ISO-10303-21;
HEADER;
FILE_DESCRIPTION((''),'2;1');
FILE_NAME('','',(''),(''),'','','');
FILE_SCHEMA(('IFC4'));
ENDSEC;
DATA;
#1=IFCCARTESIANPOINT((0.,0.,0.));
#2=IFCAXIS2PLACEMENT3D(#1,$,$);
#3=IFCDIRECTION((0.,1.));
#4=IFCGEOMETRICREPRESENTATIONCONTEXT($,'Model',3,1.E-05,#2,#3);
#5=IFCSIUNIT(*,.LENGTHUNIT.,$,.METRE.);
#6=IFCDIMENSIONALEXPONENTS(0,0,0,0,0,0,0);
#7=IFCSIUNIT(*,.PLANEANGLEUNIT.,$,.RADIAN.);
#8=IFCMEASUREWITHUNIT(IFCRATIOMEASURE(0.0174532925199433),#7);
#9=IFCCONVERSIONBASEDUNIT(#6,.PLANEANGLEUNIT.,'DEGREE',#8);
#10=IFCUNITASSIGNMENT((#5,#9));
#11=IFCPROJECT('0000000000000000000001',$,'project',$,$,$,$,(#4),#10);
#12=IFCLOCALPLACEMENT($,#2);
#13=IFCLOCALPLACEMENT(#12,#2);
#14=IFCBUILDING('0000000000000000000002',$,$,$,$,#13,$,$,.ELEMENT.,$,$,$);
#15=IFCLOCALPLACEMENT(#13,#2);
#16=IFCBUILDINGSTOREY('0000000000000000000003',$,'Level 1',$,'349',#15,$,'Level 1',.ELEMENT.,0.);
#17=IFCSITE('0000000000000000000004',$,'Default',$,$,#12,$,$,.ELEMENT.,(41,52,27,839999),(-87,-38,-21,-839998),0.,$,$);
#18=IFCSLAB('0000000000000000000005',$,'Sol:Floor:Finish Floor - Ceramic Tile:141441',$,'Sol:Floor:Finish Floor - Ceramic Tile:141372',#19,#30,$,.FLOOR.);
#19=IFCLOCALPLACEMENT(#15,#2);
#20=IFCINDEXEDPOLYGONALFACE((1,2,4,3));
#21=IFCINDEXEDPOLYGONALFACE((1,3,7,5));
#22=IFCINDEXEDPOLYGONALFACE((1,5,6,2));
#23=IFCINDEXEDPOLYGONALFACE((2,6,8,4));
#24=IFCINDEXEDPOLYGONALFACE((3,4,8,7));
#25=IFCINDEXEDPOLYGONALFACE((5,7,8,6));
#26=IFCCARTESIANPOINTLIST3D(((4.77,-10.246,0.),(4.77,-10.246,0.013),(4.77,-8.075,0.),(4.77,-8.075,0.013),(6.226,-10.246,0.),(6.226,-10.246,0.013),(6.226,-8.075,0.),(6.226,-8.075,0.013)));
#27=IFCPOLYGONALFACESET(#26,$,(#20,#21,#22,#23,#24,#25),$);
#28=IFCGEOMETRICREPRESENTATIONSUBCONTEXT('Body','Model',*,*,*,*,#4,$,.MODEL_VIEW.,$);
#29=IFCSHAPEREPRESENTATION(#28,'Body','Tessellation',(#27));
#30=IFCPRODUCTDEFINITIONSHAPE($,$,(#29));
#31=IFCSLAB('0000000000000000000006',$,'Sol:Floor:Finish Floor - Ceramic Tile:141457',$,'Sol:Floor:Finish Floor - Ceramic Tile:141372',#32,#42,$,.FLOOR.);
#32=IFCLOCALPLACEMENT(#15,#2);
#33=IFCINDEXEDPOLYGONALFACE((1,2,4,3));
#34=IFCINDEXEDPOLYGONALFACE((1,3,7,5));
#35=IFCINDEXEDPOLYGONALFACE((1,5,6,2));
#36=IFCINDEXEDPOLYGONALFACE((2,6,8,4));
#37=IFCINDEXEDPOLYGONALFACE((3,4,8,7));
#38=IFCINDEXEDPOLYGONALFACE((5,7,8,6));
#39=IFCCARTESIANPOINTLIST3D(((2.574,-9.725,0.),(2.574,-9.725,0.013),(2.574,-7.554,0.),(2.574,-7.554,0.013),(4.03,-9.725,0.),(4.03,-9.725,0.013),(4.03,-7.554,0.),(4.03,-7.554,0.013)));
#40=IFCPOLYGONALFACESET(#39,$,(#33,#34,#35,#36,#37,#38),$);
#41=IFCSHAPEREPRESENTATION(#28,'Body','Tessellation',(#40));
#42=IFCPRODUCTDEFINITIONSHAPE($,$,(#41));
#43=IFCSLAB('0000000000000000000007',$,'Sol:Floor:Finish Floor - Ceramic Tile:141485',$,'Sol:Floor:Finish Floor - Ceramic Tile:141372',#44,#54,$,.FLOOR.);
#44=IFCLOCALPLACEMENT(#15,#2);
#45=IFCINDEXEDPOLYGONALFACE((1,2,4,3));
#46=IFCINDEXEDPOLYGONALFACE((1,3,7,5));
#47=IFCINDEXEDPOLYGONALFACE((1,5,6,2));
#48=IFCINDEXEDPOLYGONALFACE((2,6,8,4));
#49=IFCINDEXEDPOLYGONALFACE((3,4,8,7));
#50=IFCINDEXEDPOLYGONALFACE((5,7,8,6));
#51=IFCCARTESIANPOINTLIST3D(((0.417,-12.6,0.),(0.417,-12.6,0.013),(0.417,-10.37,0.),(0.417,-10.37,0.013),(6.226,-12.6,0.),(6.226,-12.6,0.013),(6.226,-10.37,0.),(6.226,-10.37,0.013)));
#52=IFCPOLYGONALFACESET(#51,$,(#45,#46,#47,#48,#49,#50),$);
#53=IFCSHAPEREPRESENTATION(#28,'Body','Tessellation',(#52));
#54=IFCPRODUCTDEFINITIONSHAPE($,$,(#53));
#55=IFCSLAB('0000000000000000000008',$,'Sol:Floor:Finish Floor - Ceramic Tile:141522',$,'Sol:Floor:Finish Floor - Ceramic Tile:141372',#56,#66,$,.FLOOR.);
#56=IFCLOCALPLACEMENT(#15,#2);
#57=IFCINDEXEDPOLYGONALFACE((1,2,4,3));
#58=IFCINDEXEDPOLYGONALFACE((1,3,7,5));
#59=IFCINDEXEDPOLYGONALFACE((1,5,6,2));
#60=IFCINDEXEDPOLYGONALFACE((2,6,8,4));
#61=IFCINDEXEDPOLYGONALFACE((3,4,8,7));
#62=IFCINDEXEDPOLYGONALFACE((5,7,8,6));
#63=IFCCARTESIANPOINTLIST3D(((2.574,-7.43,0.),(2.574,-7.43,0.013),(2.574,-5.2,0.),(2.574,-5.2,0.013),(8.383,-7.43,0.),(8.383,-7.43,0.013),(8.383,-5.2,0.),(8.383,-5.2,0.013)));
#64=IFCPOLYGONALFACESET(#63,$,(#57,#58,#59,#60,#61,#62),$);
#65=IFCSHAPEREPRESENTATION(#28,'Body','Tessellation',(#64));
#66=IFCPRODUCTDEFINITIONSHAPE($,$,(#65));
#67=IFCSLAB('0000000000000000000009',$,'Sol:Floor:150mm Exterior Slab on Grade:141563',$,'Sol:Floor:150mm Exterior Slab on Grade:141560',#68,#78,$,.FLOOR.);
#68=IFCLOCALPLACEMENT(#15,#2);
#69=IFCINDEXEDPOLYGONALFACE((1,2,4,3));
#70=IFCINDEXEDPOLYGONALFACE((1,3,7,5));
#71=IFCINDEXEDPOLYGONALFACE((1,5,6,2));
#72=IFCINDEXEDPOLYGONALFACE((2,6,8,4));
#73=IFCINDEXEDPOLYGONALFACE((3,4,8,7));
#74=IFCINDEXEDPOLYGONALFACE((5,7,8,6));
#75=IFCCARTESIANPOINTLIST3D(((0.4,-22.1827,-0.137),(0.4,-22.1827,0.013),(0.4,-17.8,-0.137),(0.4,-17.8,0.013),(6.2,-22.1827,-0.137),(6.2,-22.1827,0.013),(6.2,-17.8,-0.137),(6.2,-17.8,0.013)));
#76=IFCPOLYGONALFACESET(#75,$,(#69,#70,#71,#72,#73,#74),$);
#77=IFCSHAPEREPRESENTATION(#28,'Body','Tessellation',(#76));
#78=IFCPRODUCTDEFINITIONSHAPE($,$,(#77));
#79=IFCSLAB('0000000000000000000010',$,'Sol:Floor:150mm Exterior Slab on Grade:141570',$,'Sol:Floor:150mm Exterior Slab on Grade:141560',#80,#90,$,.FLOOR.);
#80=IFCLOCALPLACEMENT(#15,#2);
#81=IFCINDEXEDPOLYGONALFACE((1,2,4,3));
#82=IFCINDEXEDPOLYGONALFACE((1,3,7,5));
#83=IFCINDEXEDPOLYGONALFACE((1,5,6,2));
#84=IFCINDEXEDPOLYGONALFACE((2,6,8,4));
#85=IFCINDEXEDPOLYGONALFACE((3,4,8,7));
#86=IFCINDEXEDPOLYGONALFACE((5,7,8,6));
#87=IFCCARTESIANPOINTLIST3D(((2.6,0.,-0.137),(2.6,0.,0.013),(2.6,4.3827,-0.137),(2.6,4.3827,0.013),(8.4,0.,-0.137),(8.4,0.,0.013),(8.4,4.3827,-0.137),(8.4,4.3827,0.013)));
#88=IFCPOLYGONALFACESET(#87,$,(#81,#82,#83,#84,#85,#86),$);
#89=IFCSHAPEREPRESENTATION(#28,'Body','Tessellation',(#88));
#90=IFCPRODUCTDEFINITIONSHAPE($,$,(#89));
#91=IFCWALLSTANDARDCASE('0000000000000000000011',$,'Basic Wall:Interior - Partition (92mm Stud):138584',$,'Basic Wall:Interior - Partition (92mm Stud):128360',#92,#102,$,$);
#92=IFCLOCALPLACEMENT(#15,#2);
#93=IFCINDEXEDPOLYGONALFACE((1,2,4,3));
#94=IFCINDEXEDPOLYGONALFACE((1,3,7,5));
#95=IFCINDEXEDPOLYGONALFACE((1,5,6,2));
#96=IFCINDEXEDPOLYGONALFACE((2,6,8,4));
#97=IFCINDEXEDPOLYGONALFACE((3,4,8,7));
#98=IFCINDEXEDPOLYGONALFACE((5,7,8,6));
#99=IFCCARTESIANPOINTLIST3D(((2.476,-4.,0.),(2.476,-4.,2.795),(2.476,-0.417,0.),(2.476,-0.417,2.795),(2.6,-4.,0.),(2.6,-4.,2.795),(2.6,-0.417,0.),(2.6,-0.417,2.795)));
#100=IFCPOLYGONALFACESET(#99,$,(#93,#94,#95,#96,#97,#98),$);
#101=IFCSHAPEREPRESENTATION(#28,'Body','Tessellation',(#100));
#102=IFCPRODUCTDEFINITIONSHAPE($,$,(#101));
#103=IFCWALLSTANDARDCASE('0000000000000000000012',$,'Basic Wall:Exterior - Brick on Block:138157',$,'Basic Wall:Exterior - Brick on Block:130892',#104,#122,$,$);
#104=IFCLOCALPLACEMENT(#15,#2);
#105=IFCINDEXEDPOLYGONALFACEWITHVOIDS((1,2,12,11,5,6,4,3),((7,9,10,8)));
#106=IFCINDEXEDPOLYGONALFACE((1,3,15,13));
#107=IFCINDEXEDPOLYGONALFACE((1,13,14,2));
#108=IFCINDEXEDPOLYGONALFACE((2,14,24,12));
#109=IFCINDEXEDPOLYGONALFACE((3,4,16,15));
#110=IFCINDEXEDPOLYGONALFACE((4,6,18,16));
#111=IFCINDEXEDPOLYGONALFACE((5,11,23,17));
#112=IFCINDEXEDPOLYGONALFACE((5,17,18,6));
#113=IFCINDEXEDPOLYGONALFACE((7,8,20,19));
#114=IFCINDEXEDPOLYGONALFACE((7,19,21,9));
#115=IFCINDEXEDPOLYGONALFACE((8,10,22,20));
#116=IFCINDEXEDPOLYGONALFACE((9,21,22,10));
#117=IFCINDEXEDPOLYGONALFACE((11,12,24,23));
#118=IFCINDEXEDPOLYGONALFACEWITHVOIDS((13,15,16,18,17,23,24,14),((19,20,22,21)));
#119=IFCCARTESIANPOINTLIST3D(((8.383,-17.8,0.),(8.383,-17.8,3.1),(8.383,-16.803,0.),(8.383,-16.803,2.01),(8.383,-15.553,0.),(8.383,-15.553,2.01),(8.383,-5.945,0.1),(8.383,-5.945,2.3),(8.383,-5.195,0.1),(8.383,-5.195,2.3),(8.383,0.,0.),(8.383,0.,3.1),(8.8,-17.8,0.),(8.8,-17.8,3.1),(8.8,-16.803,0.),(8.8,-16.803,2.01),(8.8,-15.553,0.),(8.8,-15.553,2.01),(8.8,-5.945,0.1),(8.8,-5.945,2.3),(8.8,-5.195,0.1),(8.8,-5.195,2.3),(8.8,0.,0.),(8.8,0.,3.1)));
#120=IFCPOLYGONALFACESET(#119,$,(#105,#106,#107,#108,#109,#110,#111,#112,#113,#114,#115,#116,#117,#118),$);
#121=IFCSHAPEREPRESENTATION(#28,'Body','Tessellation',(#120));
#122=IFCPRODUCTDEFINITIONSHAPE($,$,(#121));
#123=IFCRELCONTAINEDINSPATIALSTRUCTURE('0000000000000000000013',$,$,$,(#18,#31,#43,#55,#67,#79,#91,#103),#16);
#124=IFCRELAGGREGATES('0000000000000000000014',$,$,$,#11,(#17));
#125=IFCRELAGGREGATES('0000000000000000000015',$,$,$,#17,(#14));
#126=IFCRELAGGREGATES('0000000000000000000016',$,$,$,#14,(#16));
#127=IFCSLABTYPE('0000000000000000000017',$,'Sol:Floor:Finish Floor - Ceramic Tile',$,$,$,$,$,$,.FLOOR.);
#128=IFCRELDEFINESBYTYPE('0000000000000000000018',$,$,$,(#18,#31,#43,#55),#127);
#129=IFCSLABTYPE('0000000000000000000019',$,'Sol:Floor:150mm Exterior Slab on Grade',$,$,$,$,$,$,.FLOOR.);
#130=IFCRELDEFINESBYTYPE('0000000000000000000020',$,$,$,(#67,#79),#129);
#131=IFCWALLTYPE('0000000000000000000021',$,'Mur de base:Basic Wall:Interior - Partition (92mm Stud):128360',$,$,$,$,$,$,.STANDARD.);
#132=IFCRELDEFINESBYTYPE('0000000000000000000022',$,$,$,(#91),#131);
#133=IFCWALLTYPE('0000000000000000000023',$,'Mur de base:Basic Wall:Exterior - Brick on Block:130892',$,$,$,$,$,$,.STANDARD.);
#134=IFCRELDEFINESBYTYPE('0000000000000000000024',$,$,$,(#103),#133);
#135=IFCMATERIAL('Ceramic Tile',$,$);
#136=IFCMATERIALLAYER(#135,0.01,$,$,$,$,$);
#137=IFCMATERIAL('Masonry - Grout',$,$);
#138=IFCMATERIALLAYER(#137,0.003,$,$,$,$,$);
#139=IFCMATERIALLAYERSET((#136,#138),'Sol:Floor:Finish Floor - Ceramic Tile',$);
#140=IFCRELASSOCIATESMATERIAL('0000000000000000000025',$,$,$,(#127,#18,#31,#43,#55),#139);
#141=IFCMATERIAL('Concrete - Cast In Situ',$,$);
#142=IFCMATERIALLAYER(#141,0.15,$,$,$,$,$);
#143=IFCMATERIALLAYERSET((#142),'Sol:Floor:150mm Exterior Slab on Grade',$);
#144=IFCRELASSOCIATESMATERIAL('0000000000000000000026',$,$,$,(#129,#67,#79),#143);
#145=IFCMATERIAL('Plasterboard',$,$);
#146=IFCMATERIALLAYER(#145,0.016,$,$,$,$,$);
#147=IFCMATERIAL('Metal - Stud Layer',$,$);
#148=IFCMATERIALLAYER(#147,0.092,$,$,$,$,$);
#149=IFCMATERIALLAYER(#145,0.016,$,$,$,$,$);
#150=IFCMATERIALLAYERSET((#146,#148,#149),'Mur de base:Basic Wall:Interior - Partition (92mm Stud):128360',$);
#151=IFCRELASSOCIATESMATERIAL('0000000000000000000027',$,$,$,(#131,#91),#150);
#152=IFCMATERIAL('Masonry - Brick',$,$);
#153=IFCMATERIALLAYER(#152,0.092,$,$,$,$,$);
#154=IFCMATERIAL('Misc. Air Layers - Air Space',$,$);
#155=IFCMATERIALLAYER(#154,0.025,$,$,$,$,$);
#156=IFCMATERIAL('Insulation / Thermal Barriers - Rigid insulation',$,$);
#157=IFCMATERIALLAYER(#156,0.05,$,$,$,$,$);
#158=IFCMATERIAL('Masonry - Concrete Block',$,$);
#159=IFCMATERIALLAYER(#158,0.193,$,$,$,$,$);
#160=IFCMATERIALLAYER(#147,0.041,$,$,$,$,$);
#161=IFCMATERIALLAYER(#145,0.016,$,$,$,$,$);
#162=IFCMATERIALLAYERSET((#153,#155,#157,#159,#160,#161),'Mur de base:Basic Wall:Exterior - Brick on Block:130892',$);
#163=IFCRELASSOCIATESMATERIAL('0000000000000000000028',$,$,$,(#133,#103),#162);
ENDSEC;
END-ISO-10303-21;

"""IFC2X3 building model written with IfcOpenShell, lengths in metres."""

from ifc_helpers import new_model, entity, si_unit, converted_unit, direction, frame, frame_2d, origin, origin_2d_with_axis, place, context, subcontext, project, spatial, rectangle, extrude, material, layer, layer_set, layer_usage, type_object, element, save


model = new_model("IFC2X3")

# Units and contexts
model_context = context("Model", 3, precision=1e-05, world=origin(), true_north=direction((0.0, 1.0)))
body_context = subcontext(model_context, "Body", "Model", "MODEL_VIEW")
ifc_project = project(units=[si_unit("LENGTHUNIT", "METRE"), converted_unit("PLANEANGLEUNIT", "DEGREE", entity("IfcRatioMeasure", 0.0174532925199433), si_unit("PLANEANGLEUNIT", "RADIAN"), dimensions=[0, 0, 0, 0, 0, 0, 0])], contexts=[model_context])

# Site, building, storey
site_placement = place(None, origin())
site = spatial("IfcSite", under=ifc_project, at=site_placement, Name="Default", CompositionType="ELEMENT", RefLatitude=(41, 52, 27, 839999), RefLongitude=(-87, -38, -21, -839998), RefElevation=0.0)
building_placement = place(site_placement, origin())
building = spatial("IfcBuilding", under=site, at=building_placement, CompositionType="ELEMENT")
storey_placement = place(building_placement, origin())
storey = spatial("IfcBuildingStorey", under=building, at=storey_placement, Name="Level 1", ObjectType="349", LongName="Level 1", CompositionType="ELEMENT", Elevation=0.0)

# Slabs
ifc_material_1 = material(Name="Ceramic Tile")
ifc_layer_1 = layer(ifc_material_1, 0.01)
ifc_material_2 = material(Name="Masonry - Grout")
ifc_layer_2 = layer(ifc_material_2, 0.003)
ifc_layer_set_1 = layer_set([ifc_layer_1, ifc_layer_2], Name="Sol:Floor:Finish Floor - Ceramic Tile")
ifc_layer_usage_1 = layer_usage(ifc_layer_set_1, "AXIS3", "POSITIVE", 0.0)
slab_type_1 = type_object("IfcSlabType", Name="Sol:Floor:Finish Floor - Ceramic Tile", PredefinedType="FLOOR", material=ifc_layer_set_1)
slab_1_placement = place(storey_placement, origin())
element("IfcSlab", 1, at=slab_1_placement, inside=storey, type_object=slab_type_1, material=ifc_layer_usage_1, Name="Sol:Floor:Finish Floor - Ceramic Tile:141441", ObjectType="Sol:Floor:Finish Floor - Ceramic Tile:141372", PredefinedType="FLOOR", context=body_context, shape_type="SweptSolid", body=[
    extrude(rectangle(XDim=2.171, YDim=1.456, at=frame_2d((0.0, 0.0), x_axis=(1.0, 0.0))), frame((5.498, -9.1605, 0.013), z_axis=(0.0, 0.0, -1.0), x_axis=(0.0, 1.0, 0.0)), (0.0, 0.0, 1.0), 0.013),
])
ifc_layer_usage_2 = layer_usage(ifc_layer_set_1, "AXIS3", "POSITIVE", 0.0)
slab_2_placement = place(storey_placement, origin())
element("IfcSlab", 2, at=slab_2_placement, inside=storey, type_object=slab_type_1, material=ifc_layer_usage_2, Name="Sol:Floor:Finish Floor - Ceramic Tile:141457", ObjectType="Sol:Floor:Finish Floor - Ceramic Tile:141372", PredefinedType="FLOOR", context=body_context, shape_type="SweptSolid", body=[
    extrude(rectangle(XDim=2.171, YDim=1.456, at=frame_2d((0.0, 0.0), x_axis=(1.0, 0.0))), frame((3.302, -8.6395, 0.013), z_axis=(0.0, 0.0, -1.0), x_axis=(0.0, 1.0, 0.0)), (0.0, 0.0, 1.0), 0.013),
])
ifc_layer_usage_3 = layer_usage(ifc_layer_set_1, "AXIS3", "POSITIVE", 0.0)
slab_3_placement = place(storey_placement, origin())
element("IfcSlab", 3, at=slab_3_placement, inside=storey, type_object=slab_type_1, material=ifc_layer_usage_3, Name="Sol:Floor:Finish Floor - Ceramic Tile:141485", ObjectType="Sol:Floor:Finish Floor - Ceramic Tile:141372", PredefinedType="FLOOR", context=body_context, shape_type="SweptSolid", body=[
    extrude(rectangle(XDim=2.23, YDim=5.809, at=origin_2d_with_axis()), frame((3.3215, -11.485, 0.013), z_axis=(0.0, 0.0, -1.0), x_axis=(0.0, 1.0, 0.0)), (0.0, 0.0, 1.0), 0.013),
])
ifc_layer_usage_4 = layer_usage(ifc_layer_set_1, "AXIS3", "POSITIVE", 0.0)
slab_4_placement = place(storey_placement, origin())
element("IfcSlab", 4, at=slab_4_placement, inside=storey, type_object=slab_type_1, material=ifc_layer_usage_4, Name="Sol:Floor:Finish Floor - Ceramic Tile:141522", ObjectType="Sol:Floor:Finish Floor - Ceramic Tile:141372", PredefinedType="FLOOR", context=body_context, shape_type="SweptSolid", body=[
    extrude(rectangle(XDim=2.23, YDim=5.809, at=frame_2d((0.0, 0.0), x_axis=(1.0, 0.0))), frame((5.4785, -6.315, 0.013), z_axis=(0.0, 0.0, -1.0), x_axis=(0.0, 1.0, 0.0)), (0.0, 0.0, 1.0), 0.013),
])
ifc_material_3 = material(Name="Concrete - Cast In Situ")
ifc_layer_3 = layer(ifc_material_3, 0.15)
ifc_layer_set_2 = layer_set([ifc_layer_3], Name="Sol:Floor:150mm Exterior Slab on Grade")
ifc_layer_usage_5 = layer_usage(ifc_layer_set_2, "AXIS3", "POSITIVE", 0.0)
slab_type_2 = type_object("IfcSlabType", Name="Sol:Floor:150mm Exterior Slab on Grade", PredefinedType="FLOOR", material=ifc_layer_set_2)
slab_5_placement = place(storey_placement, origin())
element("IfcSlab", 5, at=slab_5_placement, inside=storey, type_object=slab_type_2, material=ifc_layer_usage_5, Name="Sol:Floor:150mm Exterior Slab on Grade:141563", ObjectType="Sol:Floor:150mm Exterior Slab on Grade:141560", PredefinedType="FLOOR", context=body_context, shape_type="SweptSolid", body=[
    extrude(rectangle(XDim=4.3827, YDim=5.8, at=origin_2d_with_axis()), frame((3.3, -19.9914, 0.013), z_axis=(0.0, 0.0, -1.0), x_axis=(0.0, 1.0, 0.0)), (0.0, 0.0, 1.0), 0.15),
])
ifc_layer_usage_6 = layer_usage(ifc_layer_set_2, "AXIS3", "POSITIVE", 0.0)
slab_6_placement = place(storey_placement, origin())
element("IfcSlab", 6, at=slab_6_placement, inside=storey, type_object=slab_type_2, material=ifc_layer_usage_6, Name="Sol:Floor:150mm Exterior Slab on Grade:141570", ObjectType="Sol:Floor:150mm Exterior Slab on Grade:141560", PredefinedType="FLOOR", context=body_context, shape_type="SweptSolid", body=[
    extrude(rectangle(XDim=4.3827, YDim=5.8, at=origin_2d_with_axis()), frame((5.5, 2.1914, 0.013), z_axis=(0.0, 0.0, -1.0), x_axis=(0.0, 1.0, 0.0)), (0.0, 0.0, 1.0), 0.15),
])

# Shared definitions
ifc_material_4 = material(Name="Plasterboard")
ifc_layer_4 = layer(ifc_material_4, 0.016)
ifc_material_5 = material(Name="Metal - Stud Layer")
ifc_layer_5 = layer(ifc_material_5, 0.092)
ifc_layer_6 = layer(ifc_material_4, 0.016)
ifc_layer_set_3 = layer_set([ifc_layer_4, ifc_layer_5, ifc_layer_6], Name="Mur de base:Basic Wall:Interior - Partition (92mm Stud):128360")
wall_type_1 = type_object("IfcWallType", Name="Mur de base:Basic Wall:Interior - Partition (92mm Stud):128360", PredefinedType="STANDARD", material=ifc_layer_set_3)

# Wall
ifc_layer_usage_7 = layer_usage(ifc_layer_set_3, "AXIS2", "NEGATIVE", 0.062)
wall_1_placement = place(storey_placement, frame((2.538, -0.417, 0.0), z_axis=(0.0, 0.0, 1.0), x_axis=(0.0, -1.0, 0.0)))
element("IfcWallStandardCase", 7, at=wall_1_placement, inside=storey, type_object=wall_type_1, material=ifc_layer_usage_7, Name="Basic Wall:Interior - Partition (92mm Stud):138584", ObjectType="Basic Wall:Interior - Partition (92mm Stud):128360", context=body_context, shape_type="SweptSolid", body=[
    extrude(rectangle(XDim=3.583, YDim=0.124, at=frame_2d((1.7915, 0.0), x_axis=(-1.0, 0.0))), origin(), (0.0, 0.0, 1.0), 2.795),
])

# Wall, openings
ifc_material_6 = material(Name="Masonry - Brick")
ifc_layer_7 = layer(ifc_material_6, 0.092)
ifc_material_7 = material(Name="Misc. Air Layers - Air Space")
ifc_layer_8 = layer(ifc_material_7, 0.025)
ifc_material_8 = material(Name="Insulation / Thermal Barriers - Rigid insulation")
ifc_layer_9 = layer(ifc_material_8, 0.05)
ifc_material_9 = material(Name="Masonry - Concrete Block")
ifc_layer_10 = layer(ifc_material_9, 0.193)
ifc_layer_11 = layer(ifc_material_5, 0.041)
ifc_layer_12 = layer(ifc_material_4, 0.016)
ifc_layer_set_4 = layer_set([ifc_layer_7, ifc_layer_8, ifc_layer_9, ifc_layer_10, ifc_layer_11, ifc_layer_12], Name="Mur de base:Basic Wall:Exterior - Brick on Block:130892")
ifc_layer_usage_8 = layer_usage(ifc_layer_set_4, "AXIS2", "NEGATIVE", 0.2085)
wall_type_2 = type_object("IfcWallType", Name="Mur de base:Basic Wall:Exterior - Brick on Block:130892", PredefinedType="STANDARD", material=ifc_layer_set_4)
wall_2_placement = place(storey_placement, frame((8.5915, 0.0, 0.0), z_axis=(0.0, 0.0, 1.0), x_axis=(0.0, -1.0, 0.0)))
wall_2 = element("IfcWallStandardCase", 8, at=wall_2_placement, inside=storey, type_object=wall_type_2, material=ifc_layer_usage_8, Name="Basic Wall:Exterior - Brick on Block:138157", ObjectType="Basic Wall:Exterior - Brick on Block:130892", context=body_context, shape_type="SweptSolid", body=[
    extrude(rectangle(XDim=17.8, YDim=0.417, at=frame_2d((8.9, 0.0), x_axis=(-1.0, 0.0))), origin(), (0.0, 0.0, 1.0), 3.1),
])
opening_1_placement = place(wall_2_placement, origin())
element("IfcOpeningElement", 9, at=opening_1_placement, cuts=wall_2, ObjectType="Opening", context=body_context, shape_type="SweptSolid", body=[
    extrude(rectangle(XDim=2.01, YDim=1.25, at=frame_2d((0.0, 0.0), x_axis=(1.0, 0.0))), frame((16.178, -0.2127, 1.005), z_axis=(0.0, 1.0, 0.0), x_axis=(0.0, 0.0, -1.0)), (0.0, 0.0, 1.0), 0.4253),
])
opening_2_placement = place(wall_2_placement, origin())
element("IfcOpeningElement", 10, at=opening_2_placement, cuts=wall_2, ObjectType="Opening", context=body_context, shape_type="SweptSolid", body=[
    extrude(rectangle(XDim=2.2, YDim=0.75, at=frame_2d((0.0, 0.0), x_axis=(0.0, 1.0))), frame((5.57, -0.2127, 1.2), z_axis=(0.0, 1.0, 0.0), x_axis=(1.0, 0.0, 0.0)), (0.0, 0.0, 1.0), 0.4253),
])

save(model, "model.ifc")
